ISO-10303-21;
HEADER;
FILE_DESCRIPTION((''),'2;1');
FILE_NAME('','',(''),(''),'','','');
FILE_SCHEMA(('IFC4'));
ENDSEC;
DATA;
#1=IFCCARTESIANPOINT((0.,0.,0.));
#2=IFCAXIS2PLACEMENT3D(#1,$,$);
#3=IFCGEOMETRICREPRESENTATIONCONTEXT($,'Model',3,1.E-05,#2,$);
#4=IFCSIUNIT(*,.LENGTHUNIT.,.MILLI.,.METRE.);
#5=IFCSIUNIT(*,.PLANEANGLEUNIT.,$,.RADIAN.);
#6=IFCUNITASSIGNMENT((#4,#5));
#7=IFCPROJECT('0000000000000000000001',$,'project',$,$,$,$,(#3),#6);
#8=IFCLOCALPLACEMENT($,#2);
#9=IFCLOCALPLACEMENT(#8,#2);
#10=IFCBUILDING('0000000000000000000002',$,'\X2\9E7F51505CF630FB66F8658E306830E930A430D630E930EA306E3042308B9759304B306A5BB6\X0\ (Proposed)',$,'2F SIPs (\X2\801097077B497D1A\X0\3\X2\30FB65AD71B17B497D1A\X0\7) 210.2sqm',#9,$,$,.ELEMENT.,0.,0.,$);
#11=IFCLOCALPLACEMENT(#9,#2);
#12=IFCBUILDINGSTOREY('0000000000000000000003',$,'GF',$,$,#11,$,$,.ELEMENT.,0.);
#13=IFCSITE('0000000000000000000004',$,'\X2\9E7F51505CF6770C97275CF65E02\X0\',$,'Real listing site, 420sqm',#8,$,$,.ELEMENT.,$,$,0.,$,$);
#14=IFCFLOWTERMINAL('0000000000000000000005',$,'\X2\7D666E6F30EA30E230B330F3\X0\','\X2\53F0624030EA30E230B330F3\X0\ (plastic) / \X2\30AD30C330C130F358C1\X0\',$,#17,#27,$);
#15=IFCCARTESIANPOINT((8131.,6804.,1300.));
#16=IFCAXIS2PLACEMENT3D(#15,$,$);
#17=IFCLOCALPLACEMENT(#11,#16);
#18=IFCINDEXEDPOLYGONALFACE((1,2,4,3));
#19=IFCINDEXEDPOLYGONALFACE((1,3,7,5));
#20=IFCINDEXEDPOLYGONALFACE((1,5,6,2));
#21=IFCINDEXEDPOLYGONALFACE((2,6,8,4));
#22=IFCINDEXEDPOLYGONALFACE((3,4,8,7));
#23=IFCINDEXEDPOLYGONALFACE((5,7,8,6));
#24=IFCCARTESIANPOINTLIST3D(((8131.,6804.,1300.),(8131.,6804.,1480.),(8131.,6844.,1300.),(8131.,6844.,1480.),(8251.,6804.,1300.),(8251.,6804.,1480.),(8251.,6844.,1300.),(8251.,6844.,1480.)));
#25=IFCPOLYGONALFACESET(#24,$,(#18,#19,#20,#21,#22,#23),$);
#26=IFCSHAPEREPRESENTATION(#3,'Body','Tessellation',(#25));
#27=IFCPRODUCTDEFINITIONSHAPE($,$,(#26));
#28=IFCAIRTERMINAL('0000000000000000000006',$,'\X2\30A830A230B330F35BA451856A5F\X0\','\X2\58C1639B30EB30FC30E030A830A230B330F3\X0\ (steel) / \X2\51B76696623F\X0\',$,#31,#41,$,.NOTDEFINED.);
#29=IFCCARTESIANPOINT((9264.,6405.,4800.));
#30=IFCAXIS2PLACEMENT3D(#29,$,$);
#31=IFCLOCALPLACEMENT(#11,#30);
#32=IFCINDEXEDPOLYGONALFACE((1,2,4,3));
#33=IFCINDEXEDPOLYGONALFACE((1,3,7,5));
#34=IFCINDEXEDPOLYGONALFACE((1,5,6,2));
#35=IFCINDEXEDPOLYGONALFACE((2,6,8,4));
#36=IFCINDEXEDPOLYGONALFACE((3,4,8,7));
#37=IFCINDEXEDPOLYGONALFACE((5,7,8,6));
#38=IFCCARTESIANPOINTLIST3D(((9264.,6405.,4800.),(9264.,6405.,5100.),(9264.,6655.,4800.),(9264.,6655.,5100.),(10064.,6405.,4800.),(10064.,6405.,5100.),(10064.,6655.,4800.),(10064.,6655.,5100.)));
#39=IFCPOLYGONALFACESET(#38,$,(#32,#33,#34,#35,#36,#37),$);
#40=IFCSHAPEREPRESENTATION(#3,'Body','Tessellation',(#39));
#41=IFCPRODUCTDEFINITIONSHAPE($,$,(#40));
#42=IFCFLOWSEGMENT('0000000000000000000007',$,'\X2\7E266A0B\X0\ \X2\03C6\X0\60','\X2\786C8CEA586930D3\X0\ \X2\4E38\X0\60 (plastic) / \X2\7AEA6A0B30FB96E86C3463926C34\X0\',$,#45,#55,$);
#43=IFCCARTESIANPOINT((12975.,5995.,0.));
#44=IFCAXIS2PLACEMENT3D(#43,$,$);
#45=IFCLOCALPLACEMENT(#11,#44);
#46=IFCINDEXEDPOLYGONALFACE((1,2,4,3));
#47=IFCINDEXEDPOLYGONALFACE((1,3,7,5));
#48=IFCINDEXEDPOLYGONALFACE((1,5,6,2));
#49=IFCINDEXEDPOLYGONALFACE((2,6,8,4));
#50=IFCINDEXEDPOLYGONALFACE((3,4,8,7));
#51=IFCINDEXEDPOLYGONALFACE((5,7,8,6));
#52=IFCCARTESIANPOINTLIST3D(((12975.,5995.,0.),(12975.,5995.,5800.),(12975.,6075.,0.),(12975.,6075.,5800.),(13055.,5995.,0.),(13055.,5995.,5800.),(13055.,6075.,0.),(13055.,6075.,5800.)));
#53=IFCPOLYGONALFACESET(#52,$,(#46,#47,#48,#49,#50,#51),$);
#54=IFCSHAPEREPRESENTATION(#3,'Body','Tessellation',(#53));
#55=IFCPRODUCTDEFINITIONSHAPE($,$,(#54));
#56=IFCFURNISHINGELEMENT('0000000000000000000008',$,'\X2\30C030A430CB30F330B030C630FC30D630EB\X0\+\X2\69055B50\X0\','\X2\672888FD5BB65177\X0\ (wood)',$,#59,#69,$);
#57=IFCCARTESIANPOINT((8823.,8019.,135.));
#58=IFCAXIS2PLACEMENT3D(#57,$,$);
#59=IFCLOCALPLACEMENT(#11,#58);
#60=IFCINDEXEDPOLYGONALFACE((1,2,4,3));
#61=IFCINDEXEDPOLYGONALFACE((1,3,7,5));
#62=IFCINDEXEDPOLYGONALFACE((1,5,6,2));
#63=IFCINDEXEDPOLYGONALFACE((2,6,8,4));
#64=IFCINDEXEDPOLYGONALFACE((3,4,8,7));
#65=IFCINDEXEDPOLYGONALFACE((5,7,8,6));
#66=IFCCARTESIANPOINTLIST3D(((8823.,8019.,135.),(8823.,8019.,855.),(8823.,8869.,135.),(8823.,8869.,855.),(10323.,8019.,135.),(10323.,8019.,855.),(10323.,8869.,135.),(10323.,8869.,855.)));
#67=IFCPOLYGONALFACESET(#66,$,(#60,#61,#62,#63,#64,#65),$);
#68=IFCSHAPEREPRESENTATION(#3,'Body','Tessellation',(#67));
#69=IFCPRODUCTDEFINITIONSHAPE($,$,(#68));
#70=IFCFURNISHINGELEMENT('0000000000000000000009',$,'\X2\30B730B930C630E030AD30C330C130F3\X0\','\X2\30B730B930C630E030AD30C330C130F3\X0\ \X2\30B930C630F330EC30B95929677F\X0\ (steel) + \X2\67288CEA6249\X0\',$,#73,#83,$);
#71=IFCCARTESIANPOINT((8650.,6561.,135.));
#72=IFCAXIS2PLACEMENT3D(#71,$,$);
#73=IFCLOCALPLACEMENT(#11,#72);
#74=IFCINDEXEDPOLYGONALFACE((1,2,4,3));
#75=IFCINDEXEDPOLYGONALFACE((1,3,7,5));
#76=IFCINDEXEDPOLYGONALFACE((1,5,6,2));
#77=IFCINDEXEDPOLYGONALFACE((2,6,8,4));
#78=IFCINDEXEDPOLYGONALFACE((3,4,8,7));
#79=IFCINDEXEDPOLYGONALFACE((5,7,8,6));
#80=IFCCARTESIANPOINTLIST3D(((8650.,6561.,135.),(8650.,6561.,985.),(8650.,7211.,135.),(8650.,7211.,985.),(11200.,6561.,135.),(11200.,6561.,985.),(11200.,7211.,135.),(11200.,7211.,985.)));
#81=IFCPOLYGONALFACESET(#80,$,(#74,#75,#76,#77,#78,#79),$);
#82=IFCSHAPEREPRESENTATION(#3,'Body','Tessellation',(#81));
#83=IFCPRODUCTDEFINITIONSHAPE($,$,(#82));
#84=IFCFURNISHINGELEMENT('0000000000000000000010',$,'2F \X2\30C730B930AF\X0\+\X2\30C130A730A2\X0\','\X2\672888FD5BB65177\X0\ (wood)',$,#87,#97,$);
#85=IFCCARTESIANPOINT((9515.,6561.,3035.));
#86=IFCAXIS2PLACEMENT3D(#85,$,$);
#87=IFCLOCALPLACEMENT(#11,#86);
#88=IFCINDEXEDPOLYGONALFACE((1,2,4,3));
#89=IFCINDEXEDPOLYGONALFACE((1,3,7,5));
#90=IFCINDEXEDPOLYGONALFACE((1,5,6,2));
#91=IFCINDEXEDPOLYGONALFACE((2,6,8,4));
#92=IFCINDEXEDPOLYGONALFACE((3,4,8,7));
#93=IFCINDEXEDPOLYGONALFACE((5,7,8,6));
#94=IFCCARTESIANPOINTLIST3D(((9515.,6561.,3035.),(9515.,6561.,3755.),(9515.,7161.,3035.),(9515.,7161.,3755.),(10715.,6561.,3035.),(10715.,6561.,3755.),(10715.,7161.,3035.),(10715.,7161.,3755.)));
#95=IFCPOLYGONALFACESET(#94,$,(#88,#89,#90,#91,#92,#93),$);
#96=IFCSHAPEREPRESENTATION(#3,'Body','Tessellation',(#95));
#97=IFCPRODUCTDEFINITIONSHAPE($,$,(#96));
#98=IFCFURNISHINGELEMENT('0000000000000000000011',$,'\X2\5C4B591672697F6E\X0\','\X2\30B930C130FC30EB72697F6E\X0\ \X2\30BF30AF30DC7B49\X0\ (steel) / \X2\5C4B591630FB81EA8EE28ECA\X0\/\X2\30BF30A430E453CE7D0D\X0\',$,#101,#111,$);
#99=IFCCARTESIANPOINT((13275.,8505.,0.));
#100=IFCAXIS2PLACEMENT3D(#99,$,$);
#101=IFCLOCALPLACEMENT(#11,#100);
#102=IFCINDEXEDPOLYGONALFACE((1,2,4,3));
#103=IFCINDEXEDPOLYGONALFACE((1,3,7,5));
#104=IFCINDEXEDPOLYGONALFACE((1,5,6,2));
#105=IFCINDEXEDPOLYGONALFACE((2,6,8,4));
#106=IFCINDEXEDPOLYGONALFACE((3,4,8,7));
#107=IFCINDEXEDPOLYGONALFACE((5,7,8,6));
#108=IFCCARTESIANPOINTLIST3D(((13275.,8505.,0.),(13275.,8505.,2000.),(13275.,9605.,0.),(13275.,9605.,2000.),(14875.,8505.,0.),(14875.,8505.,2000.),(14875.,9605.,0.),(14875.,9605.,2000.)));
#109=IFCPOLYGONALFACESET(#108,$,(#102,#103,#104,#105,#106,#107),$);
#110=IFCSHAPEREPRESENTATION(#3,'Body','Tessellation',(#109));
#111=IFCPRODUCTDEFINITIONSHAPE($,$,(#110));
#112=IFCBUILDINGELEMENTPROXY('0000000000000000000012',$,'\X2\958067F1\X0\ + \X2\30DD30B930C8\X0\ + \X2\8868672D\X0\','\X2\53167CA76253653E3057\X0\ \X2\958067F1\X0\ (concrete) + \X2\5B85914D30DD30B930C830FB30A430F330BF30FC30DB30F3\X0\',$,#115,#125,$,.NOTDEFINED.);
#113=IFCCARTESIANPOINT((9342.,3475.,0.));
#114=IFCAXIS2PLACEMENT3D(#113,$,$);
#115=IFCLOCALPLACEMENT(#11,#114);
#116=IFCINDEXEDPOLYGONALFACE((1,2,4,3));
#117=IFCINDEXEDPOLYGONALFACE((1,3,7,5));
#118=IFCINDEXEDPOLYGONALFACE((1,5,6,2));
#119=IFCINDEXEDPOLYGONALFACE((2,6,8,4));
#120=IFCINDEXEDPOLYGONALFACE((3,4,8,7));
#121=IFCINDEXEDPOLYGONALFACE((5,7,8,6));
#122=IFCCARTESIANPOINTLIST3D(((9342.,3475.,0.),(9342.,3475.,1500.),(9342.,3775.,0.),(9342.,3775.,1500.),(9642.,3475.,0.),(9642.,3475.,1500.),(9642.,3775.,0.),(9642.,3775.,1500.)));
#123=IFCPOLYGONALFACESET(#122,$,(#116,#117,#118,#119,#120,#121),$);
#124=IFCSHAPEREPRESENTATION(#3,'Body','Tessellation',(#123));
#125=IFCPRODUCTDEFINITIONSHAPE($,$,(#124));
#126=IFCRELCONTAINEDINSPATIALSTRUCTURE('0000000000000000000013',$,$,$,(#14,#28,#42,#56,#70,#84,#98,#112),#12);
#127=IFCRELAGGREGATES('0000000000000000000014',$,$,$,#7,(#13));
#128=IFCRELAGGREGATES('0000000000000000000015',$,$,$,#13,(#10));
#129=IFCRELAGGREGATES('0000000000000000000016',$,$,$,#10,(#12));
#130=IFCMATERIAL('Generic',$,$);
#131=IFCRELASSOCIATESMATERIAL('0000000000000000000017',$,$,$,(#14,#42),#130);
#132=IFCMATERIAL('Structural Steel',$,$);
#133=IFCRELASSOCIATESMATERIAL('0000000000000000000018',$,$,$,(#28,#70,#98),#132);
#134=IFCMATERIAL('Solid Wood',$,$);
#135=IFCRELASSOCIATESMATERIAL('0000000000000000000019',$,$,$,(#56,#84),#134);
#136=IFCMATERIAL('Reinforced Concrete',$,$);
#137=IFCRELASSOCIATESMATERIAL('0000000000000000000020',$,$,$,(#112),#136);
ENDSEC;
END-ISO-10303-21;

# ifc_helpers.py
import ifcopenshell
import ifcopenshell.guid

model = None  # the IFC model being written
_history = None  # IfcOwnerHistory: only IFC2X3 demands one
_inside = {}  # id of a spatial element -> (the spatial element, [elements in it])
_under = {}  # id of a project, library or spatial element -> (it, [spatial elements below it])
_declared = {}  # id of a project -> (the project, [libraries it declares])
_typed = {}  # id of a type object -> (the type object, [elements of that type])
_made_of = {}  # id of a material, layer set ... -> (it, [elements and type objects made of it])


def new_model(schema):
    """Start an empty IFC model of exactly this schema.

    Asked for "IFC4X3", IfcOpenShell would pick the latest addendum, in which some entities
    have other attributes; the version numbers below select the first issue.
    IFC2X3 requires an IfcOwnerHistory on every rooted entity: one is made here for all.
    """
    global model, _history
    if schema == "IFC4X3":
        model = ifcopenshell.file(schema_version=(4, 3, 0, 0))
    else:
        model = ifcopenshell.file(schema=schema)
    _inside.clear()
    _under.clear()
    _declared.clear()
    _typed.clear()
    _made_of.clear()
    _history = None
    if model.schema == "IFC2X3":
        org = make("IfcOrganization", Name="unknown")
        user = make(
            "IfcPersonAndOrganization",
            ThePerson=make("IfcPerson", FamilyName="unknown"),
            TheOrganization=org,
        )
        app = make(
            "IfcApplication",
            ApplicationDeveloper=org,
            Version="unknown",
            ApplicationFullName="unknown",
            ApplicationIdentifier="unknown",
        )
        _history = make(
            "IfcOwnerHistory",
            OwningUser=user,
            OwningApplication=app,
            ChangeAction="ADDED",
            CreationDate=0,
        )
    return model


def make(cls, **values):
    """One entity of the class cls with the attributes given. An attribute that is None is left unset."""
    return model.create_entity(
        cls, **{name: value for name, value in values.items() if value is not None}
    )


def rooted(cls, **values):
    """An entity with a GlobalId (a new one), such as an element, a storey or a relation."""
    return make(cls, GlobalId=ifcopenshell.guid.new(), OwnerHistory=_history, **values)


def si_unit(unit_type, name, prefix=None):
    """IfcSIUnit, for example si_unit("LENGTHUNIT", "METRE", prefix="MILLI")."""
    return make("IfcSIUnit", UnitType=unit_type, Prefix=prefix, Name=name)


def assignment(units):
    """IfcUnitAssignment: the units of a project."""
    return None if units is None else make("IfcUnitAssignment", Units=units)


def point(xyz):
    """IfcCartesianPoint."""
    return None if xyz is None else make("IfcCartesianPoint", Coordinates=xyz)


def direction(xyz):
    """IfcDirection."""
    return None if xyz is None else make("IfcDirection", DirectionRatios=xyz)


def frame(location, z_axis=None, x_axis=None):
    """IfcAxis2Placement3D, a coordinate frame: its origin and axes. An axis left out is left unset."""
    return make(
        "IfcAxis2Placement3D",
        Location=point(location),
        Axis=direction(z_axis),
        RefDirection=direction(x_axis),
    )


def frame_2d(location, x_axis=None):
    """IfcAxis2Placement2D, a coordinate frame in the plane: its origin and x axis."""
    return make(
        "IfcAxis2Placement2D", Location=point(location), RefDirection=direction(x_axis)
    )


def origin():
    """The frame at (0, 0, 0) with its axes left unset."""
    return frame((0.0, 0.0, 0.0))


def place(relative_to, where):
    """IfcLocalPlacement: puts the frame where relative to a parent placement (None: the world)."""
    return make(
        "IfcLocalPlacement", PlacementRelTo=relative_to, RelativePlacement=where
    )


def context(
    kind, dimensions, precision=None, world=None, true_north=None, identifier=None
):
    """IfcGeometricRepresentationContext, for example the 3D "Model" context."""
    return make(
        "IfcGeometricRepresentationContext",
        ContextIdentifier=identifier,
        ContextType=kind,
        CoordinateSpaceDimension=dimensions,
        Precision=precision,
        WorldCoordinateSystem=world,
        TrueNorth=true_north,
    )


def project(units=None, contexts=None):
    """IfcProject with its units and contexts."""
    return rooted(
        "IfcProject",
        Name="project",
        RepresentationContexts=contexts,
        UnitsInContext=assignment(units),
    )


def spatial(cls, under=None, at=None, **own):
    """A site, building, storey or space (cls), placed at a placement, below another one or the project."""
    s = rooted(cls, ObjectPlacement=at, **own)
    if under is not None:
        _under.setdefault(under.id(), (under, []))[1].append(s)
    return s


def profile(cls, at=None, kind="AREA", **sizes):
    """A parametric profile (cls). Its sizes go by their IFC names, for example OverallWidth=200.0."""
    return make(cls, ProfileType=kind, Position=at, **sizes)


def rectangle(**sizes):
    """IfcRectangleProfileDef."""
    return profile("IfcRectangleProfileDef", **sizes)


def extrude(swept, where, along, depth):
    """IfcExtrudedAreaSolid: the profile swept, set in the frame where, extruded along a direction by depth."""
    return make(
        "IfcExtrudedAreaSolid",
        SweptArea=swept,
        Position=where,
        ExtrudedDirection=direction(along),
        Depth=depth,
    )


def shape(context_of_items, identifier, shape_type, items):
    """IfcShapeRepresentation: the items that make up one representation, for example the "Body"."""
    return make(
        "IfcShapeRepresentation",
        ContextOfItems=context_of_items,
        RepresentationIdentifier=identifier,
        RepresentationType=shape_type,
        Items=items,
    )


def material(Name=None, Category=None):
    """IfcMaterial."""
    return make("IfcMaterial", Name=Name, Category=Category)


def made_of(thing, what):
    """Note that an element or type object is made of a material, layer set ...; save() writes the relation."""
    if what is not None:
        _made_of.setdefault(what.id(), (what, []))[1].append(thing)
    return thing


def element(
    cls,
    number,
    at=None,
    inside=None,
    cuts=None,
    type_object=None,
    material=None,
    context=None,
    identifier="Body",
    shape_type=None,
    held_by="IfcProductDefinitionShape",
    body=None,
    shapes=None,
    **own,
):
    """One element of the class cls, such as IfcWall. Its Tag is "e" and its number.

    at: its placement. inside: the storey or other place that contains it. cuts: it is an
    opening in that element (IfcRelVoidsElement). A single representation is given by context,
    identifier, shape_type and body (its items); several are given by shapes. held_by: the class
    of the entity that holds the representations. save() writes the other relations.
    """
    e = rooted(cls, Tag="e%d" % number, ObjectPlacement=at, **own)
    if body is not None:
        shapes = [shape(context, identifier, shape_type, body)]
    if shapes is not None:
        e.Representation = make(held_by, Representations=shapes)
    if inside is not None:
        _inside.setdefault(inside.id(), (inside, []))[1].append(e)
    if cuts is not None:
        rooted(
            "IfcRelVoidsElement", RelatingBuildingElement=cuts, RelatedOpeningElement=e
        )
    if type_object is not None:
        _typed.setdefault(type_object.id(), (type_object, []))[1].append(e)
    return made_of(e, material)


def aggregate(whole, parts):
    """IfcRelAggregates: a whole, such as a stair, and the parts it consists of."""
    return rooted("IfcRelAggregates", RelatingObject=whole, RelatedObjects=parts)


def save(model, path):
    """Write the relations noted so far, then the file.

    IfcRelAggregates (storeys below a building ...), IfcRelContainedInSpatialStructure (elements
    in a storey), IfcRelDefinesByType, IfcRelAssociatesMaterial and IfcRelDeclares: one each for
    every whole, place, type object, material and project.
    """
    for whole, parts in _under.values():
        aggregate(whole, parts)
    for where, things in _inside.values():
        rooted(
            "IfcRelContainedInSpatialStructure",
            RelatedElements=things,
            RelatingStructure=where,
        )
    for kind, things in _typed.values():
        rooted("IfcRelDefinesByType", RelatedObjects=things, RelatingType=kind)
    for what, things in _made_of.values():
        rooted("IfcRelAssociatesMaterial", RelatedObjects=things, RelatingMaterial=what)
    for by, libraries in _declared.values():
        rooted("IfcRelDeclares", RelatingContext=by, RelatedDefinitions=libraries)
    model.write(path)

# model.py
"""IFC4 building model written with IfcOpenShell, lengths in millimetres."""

from ifc_helpers import new_model, si_unit, frame, frame_2d, origin, place, context, project, spatial, rectangle, extrude, material, element, save


model = new_model("IFC4")

# Units and contexts
model_context = context("Model", 3, precision=1e-05, world=origin())
ifc_project = project(units=[si_unit("LENGTHUNIT", "METRE", prefix="MILLI"), si_unit("PLANEANGLEUNIT", "RADIAN")], contexts=[model_context])

# Site, building, storey
site_placement = place(None, origin())
site = spatial("IfcSite", under=ifc_project, at=site_placement, Name="鹿児島県霧島市", ObjectType="Real listing site, 420sqm", CompositionType="ELEMENT", RefElevation=0.0)
building_placement = place(site_placement, origin())
building = spatial("IfcBuilding", under=site, at=building_placement, Name="鹿児島・書斎とライブラリのある静かな家 (Proposed)", ObjectType="2F SIPs (耐震等級3・断熱等級7) 210.2sqm", CompositionType="ELEMENT", ElevationOfRefHeight=0.0, ElevationOfTerrain=0.0)
storey_placement = place(building_placement, origin())
storey = spatial("IfcBuildingStorey", under=building, at=storey_placement, Name="GF", CompositionType="ELEMENT", Elevation=0.0)

# Shared definitions
ifc_material_1 = material(Name="Solid Wood")

# Shared definitions
ifc_material_2 = material(Name="Reinforced Concrete")

# Shared definitions
ifc_material_3 = material(Name="Structural Steel")

# Flow terminal
ifc_material_4 = material(Name="Generic")
flow_terminal_1_placement = place(storey_placement, frame((8131.0, 6804.0, 1300.0)))
element("IfcFlowTerminal", 1, at=flow_terminal_1_placement, inside=storey, material=ifc_material_4, Name="給湯リモコン", Description="台所リモコン (plastic) / キッチン壁", context=model_context, shape_type="SweptSolid", body=[
    extrude(rectangle(XDim=120.0, YDim=40.0, at=frame_2d((60.0, 20.0))), frame((8131.0, 6804.0, 1300.0)), (0.0, 0.0, 1.0), 180.0),
])

# Air terminal
air_terminal_placement = place(storey_placement, frame((9264.0, 6405.0, 4800.0)))
element("IfcAirTerminal", 2, at=air_terminal_placement, inside=storey, material=ifc_material_3, Name="エアコン室内機", Description="壁掛ルームエアコン (steel) / 冷暖房", PredefinedType="NOTDEFINED", context=model_context, shape_type="SweptSolid", body=[
    extrude(rectangle(XDim=800.0, YDim=250.0, at=frame_2d((400.0, 125.0))), frame((9264.0, 6405.0, 4800.0)), (0.0, 0.0, 1.0), 300.0),
])

# Flow segment
flow_segment_placement = place(storey_placement, frame((12975.0, 5995.0, 0.0)))
element("IfcFlowSegment", 3, at=flow_segment_placement, inside=storey, material=ifc_material_4, Name="縦樋 φ60", Description="硬質塩ビ 丸60 (plastic) / 竪樋・雨水排水", context=model_context, shape_type="SweptSolid", body=[
    extrude(rectangle(XDim=80.0, YDim=80.0, at=frame_2d((40.0, 40.0))), frame((12975.0, 5995.0, 0.0)), (0.0, 0.0, 1.0), 5800.0),
])

# Furnishing elements
furnishing_1_placement = place(storey_placement, frame((8823.0, 8019.0, 135.0)))
element("IfcFurnishingElement", 4, at=furnishing_1_placement, inside=storey, material=ifc_material_1, Name="ダイニングテーブル+椅子", Description="木製家具 (wood)", context=model_context, shape_type="SweptSolid", body=[
    extrude(rectangle(XDim=1500.0, YDim=850.0, at=frame_2d((750.0, 425.0))), frame((8823.0, 8019.0, 135.0)), (0.0, 0.0, 1.0), 720.0),
])
furnishing_2_placement = place(storey_placement, frame((8650.0, 6561.0, 135.0)))
element("IfcFurnishingElement", 5, at=furnishing_2_placement, inside=storey, material=ifc_material_3, Name="システムキッチン", Description="システムキッチン ステンレス天板 (steel) + 木質扉", context=model_context, shape_type="SweptSolid", body=[
    extrude(rectangle(XDim=2550.0, YDim=650.0, at=frame_2d((1275.0, 325.0))), frame((8650.0, 6561.0, 135.0)), (0.0, 0.0, 1.0), 850.0),
])
furnishing_3_placement = place(storey_placement, frame((9515.0, 6561.0, 3035.0)))
element("IfcFurnishingElement", 6, at=furnishing_3_placement, inside=storey, material=ifc_material_1, Name="2F デスク+チェア", Description="木製家具 (wood)", context=model_context, shape_type="SweptSolid", body=[
    extrude(rectangle(XDim=1200.0, YDim=600.0, at=frame_2d((600.0, 300.0))), frame((9515.0, 6561.0, 3035.0)), (0.0, 0.0, 1.0), 720.0),
])
furnishing_4_placement = place(storey_placement, frame((13275.0, 8505.0, 0.0)))
element("IfcFurnishingElement", 7, at=furnishing_4_placement, inside=storey, material=ifc_material_3, Name="屋外物置", Description="スチール物置 タクボ等 (steel) / 屋外・自転車/タイヤ収納", context=model_context, shape_type="SweptSolid", body=[
    extrude(rectangle(XDim=1600.0, YDim=1100.0, at=frame_2d((800.0, 550.0))), frame((13275.0, 8505.0, 0.0)), (0.0, 0.0, 1.0), 2000.0),
])

# Building element proxy
proxy_placement = place(storey_placement, frame((9342.0, 3475.0, 0.0)))
element("IfcBuildingElementProxy", 8, at=proxy_placement, inside=storey, material=ifc_material_2, Name="門柱 + ポスト + 表札", Description="化粧打放し 門柱 (concrete) + 宅配ポスト・インターホン", PredefinedType="NOTDEFINED", context=model_context, shape_type="SweptSolid", body=[
    extrude(rectangle(XDim=300.0, YDim=300.0, at=frame_2d((150.0, 150.0))), frame((9342.0, 3475.0, 0.0)), (0.0, 0.0, 1.0), 1500.0),
])

save(model, "model.ifc")
